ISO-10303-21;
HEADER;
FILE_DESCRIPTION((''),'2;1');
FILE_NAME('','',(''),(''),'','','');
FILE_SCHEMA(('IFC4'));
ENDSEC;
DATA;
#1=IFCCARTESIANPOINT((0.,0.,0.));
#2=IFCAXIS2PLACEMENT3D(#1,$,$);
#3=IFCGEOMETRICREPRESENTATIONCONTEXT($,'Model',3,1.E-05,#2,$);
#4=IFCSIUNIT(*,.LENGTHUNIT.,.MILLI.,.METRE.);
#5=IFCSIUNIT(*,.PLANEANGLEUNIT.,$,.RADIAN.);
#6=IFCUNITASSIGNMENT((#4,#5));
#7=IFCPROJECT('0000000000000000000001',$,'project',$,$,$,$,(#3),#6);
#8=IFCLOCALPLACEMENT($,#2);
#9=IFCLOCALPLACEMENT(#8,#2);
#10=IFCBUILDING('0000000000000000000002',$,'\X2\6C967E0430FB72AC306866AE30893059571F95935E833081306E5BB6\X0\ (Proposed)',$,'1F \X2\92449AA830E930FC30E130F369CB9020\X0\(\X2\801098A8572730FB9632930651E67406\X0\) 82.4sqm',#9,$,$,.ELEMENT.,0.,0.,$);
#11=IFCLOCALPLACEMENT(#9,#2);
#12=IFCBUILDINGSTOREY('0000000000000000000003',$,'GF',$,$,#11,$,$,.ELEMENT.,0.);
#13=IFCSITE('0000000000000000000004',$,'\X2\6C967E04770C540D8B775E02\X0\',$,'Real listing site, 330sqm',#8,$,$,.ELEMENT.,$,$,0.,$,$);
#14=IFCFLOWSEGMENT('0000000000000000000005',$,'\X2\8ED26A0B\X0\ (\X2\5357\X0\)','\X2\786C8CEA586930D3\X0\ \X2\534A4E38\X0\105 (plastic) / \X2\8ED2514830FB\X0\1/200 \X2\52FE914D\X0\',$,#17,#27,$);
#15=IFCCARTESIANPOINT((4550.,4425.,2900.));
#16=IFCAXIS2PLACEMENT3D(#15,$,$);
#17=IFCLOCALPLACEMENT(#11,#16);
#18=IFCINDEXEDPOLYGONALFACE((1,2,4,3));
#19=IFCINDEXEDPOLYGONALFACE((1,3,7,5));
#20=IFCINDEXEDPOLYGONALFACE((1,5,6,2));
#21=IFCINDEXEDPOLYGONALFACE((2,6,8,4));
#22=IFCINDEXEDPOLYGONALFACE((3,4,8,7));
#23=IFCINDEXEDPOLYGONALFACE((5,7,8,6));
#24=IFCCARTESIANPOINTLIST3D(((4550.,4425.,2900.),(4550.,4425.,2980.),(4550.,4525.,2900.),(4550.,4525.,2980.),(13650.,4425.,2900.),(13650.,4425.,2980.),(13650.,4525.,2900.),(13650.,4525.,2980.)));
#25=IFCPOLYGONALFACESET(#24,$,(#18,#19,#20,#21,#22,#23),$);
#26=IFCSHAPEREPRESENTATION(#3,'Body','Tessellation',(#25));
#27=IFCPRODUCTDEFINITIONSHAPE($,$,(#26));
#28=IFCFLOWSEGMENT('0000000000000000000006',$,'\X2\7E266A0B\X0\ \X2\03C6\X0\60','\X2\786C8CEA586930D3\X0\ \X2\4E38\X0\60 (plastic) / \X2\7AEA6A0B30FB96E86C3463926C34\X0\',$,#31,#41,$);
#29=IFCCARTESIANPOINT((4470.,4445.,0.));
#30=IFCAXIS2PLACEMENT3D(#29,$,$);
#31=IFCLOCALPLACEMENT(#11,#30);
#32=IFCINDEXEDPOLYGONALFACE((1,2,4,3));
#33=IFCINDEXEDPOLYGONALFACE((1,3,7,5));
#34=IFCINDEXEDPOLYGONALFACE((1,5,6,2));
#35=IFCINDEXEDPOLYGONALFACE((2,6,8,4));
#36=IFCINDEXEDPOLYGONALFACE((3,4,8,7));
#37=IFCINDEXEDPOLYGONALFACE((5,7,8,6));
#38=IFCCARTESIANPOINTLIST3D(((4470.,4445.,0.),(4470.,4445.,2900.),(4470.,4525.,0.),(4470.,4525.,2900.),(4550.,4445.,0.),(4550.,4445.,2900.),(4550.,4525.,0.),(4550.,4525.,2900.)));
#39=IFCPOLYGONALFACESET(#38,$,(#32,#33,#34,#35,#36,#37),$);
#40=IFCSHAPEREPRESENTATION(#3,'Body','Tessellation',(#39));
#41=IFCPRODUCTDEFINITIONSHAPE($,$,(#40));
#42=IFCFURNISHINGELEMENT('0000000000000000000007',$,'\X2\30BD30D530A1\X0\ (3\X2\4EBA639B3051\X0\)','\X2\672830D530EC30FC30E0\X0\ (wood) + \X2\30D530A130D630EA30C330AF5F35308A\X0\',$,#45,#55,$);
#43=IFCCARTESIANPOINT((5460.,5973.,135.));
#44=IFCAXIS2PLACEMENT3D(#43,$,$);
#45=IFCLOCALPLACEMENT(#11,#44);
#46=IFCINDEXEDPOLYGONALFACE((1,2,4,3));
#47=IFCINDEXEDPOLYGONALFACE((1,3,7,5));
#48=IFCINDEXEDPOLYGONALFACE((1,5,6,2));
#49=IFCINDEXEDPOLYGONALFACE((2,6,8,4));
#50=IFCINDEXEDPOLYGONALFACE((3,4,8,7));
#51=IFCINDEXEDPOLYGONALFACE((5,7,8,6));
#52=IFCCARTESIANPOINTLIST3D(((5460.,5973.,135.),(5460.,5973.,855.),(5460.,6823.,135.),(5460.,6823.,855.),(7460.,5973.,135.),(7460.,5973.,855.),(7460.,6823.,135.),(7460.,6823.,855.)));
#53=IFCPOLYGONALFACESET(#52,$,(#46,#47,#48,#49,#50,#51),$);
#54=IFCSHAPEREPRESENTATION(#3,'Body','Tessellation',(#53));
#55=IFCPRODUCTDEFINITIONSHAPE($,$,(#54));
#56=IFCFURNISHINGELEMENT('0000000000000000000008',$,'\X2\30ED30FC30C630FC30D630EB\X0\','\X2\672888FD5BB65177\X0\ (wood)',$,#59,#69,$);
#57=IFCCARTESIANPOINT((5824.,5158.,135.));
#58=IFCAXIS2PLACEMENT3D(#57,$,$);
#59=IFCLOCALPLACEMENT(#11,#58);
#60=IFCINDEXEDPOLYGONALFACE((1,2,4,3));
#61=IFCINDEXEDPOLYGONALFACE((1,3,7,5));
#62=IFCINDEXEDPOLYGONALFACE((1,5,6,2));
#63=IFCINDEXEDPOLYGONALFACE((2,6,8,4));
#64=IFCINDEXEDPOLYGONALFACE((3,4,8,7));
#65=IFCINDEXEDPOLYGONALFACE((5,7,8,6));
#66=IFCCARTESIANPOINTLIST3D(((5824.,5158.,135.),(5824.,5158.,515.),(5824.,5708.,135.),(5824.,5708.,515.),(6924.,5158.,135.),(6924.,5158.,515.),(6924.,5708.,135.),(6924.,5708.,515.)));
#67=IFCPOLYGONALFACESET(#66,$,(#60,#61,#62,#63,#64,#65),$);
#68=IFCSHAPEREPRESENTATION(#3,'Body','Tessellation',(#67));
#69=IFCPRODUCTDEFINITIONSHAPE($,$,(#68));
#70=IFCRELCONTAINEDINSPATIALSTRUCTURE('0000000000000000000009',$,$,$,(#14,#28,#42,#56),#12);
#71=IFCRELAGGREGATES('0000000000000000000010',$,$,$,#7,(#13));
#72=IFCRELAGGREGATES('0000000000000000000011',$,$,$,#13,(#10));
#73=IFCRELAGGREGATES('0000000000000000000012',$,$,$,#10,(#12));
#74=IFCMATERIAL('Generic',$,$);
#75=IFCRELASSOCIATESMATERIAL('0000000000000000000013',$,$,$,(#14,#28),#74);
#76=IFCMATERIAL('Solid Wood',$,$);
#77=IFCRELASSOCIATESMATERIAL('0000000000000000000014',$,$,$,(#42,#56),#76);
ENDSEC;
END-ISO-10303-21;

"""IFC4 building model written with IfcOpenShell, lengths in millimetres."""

from ifc_helpers import new_model, si_unit, frame, frame_2d, origin, place, context, project, spatial, rectangle, extrude, material, element, save


model = new_model("IFC4")

# Units and contexts
model_context = context("Model", 3, precision=1e-05, world=origin())
ifc_project = project(units=[si_unit("LENGTHUNIT", "METRE", prefix="MILLI"), si_unit("PLANEANGLEUNIT", "RADIAN")], contexts=[model_context])

# Site, building, storey
site_placement = place(None, origin())
site = spatial("IfcSite", under=ifc_project, at=site_placement, Name="沖縄県名護市", ObjectType="Real listing site, 330sqm", CompositionType="ELEMENT", RefElevation=0.0)
building_placement = place(site_placement, origin())
building = spatial("IfcBuilding", under=site, at=building_placement, Name="沖縄・犬と暮らす土間広めの家 (Proposed)", ObjectType="1F 鉄骨ラーメン構造(耐風圧・防錆処理) 82.4sqm", CompositionType="ELEMENT", ElevationOfRefHeight=0.0, ElevationOfTerrain=0.0)
storey_placement = place(building_placement, origin())
storey = spatial("IfcBuildingStorey", under=building, at=storey_placement, Name="GF", CompositionType="ELEMENT", Elevation=0.0)

# Shared definitions
ifc_material_1 = material(Name="Solid Wood")

# Shared definitions
ifc_material_2 = material(Name="Generic")

# Flow segments
flow_segment_1_placement = place(storey_placement, frame((4550.0, 4425.0, 2900.0)))
element("IfcFlowSegment", 1, at=flow_segment_1_placement, inside=storey, material=ifc_material_2, Name="軒樋 (南)", Description="硬質塩ビ 半丸105 (plastic) / 軒先・1/200 勾配", context=model_context, shape_type="SweptSolid", body=[
    extrude(rectangle(XDim=9100.0, YDim=100.0, at=frame_2d((4550.0, 50.0))), frame((4550.0, 4425.0, 2900.0)), (0.0, 0.0, 1.0), 80.0),
])
flow_segment_2_placement = place(storey_placement, frame((4470.0, 4445.0, 0.0)))
element("IfcFlowSegment", 2, at=flow_segment_2_placement, inside=storey, material=ifc_material_2, Name="縦樋 φ60", Description="硬質塩ビ 丸60 (plastic) / 竪樋・雨水排水", context=model_context, shape_type="SweptSolid", body=[
    extrude(rectangle(XDim=80.0, YDim=80.0, at=frame_2d((40.0, 40.0))), frame((4470.0, 4445.0, 0.0)), (0.0, 0.0, 1.0), 2900.0),
])

# Furnishing elements
furnishing_1_placement = place(storey_placement, frame((5460.0, 5973.0, 135.0)))
element("IfcFurnishingElement", 3, at=furnishing_1_placement, inside=storey, material=ifc_material_1, Name="ソファ (3人掛け)", Description="木フレーム (wood) + ファブリック張り", context=model_context, shape_type="SweptSolid", body=[
    extrude(rectangle(XDim=2000.0, YDim=850.0, at=frame_2d((1000.0, 425.0))), frame((5460.0, 5973.0, 135.0)), (0.0, 0.0, 1.0), 720.0),
])
furnishing_2_placement = place(storey_placement, frame((5824.0, 5158.0, 135.0)))
element("IfcFurnishingElement", 4, at=furnishing_2_placement, inside=storey, material=ifc_material_1, Name="ローテーブル", Description="木製家具 (wood)", context=model_context, shape_type="SweptSolid", body=[
    extrude(rectangle(XDim=1100.0, YDim=550.0, at=frame_2d((550.0, 275.0))), frame((5824.0, 5158.0, 135.0)), (0.0, 0.0, 1.0), 380.0),
])

save(model, "model.ifc")
